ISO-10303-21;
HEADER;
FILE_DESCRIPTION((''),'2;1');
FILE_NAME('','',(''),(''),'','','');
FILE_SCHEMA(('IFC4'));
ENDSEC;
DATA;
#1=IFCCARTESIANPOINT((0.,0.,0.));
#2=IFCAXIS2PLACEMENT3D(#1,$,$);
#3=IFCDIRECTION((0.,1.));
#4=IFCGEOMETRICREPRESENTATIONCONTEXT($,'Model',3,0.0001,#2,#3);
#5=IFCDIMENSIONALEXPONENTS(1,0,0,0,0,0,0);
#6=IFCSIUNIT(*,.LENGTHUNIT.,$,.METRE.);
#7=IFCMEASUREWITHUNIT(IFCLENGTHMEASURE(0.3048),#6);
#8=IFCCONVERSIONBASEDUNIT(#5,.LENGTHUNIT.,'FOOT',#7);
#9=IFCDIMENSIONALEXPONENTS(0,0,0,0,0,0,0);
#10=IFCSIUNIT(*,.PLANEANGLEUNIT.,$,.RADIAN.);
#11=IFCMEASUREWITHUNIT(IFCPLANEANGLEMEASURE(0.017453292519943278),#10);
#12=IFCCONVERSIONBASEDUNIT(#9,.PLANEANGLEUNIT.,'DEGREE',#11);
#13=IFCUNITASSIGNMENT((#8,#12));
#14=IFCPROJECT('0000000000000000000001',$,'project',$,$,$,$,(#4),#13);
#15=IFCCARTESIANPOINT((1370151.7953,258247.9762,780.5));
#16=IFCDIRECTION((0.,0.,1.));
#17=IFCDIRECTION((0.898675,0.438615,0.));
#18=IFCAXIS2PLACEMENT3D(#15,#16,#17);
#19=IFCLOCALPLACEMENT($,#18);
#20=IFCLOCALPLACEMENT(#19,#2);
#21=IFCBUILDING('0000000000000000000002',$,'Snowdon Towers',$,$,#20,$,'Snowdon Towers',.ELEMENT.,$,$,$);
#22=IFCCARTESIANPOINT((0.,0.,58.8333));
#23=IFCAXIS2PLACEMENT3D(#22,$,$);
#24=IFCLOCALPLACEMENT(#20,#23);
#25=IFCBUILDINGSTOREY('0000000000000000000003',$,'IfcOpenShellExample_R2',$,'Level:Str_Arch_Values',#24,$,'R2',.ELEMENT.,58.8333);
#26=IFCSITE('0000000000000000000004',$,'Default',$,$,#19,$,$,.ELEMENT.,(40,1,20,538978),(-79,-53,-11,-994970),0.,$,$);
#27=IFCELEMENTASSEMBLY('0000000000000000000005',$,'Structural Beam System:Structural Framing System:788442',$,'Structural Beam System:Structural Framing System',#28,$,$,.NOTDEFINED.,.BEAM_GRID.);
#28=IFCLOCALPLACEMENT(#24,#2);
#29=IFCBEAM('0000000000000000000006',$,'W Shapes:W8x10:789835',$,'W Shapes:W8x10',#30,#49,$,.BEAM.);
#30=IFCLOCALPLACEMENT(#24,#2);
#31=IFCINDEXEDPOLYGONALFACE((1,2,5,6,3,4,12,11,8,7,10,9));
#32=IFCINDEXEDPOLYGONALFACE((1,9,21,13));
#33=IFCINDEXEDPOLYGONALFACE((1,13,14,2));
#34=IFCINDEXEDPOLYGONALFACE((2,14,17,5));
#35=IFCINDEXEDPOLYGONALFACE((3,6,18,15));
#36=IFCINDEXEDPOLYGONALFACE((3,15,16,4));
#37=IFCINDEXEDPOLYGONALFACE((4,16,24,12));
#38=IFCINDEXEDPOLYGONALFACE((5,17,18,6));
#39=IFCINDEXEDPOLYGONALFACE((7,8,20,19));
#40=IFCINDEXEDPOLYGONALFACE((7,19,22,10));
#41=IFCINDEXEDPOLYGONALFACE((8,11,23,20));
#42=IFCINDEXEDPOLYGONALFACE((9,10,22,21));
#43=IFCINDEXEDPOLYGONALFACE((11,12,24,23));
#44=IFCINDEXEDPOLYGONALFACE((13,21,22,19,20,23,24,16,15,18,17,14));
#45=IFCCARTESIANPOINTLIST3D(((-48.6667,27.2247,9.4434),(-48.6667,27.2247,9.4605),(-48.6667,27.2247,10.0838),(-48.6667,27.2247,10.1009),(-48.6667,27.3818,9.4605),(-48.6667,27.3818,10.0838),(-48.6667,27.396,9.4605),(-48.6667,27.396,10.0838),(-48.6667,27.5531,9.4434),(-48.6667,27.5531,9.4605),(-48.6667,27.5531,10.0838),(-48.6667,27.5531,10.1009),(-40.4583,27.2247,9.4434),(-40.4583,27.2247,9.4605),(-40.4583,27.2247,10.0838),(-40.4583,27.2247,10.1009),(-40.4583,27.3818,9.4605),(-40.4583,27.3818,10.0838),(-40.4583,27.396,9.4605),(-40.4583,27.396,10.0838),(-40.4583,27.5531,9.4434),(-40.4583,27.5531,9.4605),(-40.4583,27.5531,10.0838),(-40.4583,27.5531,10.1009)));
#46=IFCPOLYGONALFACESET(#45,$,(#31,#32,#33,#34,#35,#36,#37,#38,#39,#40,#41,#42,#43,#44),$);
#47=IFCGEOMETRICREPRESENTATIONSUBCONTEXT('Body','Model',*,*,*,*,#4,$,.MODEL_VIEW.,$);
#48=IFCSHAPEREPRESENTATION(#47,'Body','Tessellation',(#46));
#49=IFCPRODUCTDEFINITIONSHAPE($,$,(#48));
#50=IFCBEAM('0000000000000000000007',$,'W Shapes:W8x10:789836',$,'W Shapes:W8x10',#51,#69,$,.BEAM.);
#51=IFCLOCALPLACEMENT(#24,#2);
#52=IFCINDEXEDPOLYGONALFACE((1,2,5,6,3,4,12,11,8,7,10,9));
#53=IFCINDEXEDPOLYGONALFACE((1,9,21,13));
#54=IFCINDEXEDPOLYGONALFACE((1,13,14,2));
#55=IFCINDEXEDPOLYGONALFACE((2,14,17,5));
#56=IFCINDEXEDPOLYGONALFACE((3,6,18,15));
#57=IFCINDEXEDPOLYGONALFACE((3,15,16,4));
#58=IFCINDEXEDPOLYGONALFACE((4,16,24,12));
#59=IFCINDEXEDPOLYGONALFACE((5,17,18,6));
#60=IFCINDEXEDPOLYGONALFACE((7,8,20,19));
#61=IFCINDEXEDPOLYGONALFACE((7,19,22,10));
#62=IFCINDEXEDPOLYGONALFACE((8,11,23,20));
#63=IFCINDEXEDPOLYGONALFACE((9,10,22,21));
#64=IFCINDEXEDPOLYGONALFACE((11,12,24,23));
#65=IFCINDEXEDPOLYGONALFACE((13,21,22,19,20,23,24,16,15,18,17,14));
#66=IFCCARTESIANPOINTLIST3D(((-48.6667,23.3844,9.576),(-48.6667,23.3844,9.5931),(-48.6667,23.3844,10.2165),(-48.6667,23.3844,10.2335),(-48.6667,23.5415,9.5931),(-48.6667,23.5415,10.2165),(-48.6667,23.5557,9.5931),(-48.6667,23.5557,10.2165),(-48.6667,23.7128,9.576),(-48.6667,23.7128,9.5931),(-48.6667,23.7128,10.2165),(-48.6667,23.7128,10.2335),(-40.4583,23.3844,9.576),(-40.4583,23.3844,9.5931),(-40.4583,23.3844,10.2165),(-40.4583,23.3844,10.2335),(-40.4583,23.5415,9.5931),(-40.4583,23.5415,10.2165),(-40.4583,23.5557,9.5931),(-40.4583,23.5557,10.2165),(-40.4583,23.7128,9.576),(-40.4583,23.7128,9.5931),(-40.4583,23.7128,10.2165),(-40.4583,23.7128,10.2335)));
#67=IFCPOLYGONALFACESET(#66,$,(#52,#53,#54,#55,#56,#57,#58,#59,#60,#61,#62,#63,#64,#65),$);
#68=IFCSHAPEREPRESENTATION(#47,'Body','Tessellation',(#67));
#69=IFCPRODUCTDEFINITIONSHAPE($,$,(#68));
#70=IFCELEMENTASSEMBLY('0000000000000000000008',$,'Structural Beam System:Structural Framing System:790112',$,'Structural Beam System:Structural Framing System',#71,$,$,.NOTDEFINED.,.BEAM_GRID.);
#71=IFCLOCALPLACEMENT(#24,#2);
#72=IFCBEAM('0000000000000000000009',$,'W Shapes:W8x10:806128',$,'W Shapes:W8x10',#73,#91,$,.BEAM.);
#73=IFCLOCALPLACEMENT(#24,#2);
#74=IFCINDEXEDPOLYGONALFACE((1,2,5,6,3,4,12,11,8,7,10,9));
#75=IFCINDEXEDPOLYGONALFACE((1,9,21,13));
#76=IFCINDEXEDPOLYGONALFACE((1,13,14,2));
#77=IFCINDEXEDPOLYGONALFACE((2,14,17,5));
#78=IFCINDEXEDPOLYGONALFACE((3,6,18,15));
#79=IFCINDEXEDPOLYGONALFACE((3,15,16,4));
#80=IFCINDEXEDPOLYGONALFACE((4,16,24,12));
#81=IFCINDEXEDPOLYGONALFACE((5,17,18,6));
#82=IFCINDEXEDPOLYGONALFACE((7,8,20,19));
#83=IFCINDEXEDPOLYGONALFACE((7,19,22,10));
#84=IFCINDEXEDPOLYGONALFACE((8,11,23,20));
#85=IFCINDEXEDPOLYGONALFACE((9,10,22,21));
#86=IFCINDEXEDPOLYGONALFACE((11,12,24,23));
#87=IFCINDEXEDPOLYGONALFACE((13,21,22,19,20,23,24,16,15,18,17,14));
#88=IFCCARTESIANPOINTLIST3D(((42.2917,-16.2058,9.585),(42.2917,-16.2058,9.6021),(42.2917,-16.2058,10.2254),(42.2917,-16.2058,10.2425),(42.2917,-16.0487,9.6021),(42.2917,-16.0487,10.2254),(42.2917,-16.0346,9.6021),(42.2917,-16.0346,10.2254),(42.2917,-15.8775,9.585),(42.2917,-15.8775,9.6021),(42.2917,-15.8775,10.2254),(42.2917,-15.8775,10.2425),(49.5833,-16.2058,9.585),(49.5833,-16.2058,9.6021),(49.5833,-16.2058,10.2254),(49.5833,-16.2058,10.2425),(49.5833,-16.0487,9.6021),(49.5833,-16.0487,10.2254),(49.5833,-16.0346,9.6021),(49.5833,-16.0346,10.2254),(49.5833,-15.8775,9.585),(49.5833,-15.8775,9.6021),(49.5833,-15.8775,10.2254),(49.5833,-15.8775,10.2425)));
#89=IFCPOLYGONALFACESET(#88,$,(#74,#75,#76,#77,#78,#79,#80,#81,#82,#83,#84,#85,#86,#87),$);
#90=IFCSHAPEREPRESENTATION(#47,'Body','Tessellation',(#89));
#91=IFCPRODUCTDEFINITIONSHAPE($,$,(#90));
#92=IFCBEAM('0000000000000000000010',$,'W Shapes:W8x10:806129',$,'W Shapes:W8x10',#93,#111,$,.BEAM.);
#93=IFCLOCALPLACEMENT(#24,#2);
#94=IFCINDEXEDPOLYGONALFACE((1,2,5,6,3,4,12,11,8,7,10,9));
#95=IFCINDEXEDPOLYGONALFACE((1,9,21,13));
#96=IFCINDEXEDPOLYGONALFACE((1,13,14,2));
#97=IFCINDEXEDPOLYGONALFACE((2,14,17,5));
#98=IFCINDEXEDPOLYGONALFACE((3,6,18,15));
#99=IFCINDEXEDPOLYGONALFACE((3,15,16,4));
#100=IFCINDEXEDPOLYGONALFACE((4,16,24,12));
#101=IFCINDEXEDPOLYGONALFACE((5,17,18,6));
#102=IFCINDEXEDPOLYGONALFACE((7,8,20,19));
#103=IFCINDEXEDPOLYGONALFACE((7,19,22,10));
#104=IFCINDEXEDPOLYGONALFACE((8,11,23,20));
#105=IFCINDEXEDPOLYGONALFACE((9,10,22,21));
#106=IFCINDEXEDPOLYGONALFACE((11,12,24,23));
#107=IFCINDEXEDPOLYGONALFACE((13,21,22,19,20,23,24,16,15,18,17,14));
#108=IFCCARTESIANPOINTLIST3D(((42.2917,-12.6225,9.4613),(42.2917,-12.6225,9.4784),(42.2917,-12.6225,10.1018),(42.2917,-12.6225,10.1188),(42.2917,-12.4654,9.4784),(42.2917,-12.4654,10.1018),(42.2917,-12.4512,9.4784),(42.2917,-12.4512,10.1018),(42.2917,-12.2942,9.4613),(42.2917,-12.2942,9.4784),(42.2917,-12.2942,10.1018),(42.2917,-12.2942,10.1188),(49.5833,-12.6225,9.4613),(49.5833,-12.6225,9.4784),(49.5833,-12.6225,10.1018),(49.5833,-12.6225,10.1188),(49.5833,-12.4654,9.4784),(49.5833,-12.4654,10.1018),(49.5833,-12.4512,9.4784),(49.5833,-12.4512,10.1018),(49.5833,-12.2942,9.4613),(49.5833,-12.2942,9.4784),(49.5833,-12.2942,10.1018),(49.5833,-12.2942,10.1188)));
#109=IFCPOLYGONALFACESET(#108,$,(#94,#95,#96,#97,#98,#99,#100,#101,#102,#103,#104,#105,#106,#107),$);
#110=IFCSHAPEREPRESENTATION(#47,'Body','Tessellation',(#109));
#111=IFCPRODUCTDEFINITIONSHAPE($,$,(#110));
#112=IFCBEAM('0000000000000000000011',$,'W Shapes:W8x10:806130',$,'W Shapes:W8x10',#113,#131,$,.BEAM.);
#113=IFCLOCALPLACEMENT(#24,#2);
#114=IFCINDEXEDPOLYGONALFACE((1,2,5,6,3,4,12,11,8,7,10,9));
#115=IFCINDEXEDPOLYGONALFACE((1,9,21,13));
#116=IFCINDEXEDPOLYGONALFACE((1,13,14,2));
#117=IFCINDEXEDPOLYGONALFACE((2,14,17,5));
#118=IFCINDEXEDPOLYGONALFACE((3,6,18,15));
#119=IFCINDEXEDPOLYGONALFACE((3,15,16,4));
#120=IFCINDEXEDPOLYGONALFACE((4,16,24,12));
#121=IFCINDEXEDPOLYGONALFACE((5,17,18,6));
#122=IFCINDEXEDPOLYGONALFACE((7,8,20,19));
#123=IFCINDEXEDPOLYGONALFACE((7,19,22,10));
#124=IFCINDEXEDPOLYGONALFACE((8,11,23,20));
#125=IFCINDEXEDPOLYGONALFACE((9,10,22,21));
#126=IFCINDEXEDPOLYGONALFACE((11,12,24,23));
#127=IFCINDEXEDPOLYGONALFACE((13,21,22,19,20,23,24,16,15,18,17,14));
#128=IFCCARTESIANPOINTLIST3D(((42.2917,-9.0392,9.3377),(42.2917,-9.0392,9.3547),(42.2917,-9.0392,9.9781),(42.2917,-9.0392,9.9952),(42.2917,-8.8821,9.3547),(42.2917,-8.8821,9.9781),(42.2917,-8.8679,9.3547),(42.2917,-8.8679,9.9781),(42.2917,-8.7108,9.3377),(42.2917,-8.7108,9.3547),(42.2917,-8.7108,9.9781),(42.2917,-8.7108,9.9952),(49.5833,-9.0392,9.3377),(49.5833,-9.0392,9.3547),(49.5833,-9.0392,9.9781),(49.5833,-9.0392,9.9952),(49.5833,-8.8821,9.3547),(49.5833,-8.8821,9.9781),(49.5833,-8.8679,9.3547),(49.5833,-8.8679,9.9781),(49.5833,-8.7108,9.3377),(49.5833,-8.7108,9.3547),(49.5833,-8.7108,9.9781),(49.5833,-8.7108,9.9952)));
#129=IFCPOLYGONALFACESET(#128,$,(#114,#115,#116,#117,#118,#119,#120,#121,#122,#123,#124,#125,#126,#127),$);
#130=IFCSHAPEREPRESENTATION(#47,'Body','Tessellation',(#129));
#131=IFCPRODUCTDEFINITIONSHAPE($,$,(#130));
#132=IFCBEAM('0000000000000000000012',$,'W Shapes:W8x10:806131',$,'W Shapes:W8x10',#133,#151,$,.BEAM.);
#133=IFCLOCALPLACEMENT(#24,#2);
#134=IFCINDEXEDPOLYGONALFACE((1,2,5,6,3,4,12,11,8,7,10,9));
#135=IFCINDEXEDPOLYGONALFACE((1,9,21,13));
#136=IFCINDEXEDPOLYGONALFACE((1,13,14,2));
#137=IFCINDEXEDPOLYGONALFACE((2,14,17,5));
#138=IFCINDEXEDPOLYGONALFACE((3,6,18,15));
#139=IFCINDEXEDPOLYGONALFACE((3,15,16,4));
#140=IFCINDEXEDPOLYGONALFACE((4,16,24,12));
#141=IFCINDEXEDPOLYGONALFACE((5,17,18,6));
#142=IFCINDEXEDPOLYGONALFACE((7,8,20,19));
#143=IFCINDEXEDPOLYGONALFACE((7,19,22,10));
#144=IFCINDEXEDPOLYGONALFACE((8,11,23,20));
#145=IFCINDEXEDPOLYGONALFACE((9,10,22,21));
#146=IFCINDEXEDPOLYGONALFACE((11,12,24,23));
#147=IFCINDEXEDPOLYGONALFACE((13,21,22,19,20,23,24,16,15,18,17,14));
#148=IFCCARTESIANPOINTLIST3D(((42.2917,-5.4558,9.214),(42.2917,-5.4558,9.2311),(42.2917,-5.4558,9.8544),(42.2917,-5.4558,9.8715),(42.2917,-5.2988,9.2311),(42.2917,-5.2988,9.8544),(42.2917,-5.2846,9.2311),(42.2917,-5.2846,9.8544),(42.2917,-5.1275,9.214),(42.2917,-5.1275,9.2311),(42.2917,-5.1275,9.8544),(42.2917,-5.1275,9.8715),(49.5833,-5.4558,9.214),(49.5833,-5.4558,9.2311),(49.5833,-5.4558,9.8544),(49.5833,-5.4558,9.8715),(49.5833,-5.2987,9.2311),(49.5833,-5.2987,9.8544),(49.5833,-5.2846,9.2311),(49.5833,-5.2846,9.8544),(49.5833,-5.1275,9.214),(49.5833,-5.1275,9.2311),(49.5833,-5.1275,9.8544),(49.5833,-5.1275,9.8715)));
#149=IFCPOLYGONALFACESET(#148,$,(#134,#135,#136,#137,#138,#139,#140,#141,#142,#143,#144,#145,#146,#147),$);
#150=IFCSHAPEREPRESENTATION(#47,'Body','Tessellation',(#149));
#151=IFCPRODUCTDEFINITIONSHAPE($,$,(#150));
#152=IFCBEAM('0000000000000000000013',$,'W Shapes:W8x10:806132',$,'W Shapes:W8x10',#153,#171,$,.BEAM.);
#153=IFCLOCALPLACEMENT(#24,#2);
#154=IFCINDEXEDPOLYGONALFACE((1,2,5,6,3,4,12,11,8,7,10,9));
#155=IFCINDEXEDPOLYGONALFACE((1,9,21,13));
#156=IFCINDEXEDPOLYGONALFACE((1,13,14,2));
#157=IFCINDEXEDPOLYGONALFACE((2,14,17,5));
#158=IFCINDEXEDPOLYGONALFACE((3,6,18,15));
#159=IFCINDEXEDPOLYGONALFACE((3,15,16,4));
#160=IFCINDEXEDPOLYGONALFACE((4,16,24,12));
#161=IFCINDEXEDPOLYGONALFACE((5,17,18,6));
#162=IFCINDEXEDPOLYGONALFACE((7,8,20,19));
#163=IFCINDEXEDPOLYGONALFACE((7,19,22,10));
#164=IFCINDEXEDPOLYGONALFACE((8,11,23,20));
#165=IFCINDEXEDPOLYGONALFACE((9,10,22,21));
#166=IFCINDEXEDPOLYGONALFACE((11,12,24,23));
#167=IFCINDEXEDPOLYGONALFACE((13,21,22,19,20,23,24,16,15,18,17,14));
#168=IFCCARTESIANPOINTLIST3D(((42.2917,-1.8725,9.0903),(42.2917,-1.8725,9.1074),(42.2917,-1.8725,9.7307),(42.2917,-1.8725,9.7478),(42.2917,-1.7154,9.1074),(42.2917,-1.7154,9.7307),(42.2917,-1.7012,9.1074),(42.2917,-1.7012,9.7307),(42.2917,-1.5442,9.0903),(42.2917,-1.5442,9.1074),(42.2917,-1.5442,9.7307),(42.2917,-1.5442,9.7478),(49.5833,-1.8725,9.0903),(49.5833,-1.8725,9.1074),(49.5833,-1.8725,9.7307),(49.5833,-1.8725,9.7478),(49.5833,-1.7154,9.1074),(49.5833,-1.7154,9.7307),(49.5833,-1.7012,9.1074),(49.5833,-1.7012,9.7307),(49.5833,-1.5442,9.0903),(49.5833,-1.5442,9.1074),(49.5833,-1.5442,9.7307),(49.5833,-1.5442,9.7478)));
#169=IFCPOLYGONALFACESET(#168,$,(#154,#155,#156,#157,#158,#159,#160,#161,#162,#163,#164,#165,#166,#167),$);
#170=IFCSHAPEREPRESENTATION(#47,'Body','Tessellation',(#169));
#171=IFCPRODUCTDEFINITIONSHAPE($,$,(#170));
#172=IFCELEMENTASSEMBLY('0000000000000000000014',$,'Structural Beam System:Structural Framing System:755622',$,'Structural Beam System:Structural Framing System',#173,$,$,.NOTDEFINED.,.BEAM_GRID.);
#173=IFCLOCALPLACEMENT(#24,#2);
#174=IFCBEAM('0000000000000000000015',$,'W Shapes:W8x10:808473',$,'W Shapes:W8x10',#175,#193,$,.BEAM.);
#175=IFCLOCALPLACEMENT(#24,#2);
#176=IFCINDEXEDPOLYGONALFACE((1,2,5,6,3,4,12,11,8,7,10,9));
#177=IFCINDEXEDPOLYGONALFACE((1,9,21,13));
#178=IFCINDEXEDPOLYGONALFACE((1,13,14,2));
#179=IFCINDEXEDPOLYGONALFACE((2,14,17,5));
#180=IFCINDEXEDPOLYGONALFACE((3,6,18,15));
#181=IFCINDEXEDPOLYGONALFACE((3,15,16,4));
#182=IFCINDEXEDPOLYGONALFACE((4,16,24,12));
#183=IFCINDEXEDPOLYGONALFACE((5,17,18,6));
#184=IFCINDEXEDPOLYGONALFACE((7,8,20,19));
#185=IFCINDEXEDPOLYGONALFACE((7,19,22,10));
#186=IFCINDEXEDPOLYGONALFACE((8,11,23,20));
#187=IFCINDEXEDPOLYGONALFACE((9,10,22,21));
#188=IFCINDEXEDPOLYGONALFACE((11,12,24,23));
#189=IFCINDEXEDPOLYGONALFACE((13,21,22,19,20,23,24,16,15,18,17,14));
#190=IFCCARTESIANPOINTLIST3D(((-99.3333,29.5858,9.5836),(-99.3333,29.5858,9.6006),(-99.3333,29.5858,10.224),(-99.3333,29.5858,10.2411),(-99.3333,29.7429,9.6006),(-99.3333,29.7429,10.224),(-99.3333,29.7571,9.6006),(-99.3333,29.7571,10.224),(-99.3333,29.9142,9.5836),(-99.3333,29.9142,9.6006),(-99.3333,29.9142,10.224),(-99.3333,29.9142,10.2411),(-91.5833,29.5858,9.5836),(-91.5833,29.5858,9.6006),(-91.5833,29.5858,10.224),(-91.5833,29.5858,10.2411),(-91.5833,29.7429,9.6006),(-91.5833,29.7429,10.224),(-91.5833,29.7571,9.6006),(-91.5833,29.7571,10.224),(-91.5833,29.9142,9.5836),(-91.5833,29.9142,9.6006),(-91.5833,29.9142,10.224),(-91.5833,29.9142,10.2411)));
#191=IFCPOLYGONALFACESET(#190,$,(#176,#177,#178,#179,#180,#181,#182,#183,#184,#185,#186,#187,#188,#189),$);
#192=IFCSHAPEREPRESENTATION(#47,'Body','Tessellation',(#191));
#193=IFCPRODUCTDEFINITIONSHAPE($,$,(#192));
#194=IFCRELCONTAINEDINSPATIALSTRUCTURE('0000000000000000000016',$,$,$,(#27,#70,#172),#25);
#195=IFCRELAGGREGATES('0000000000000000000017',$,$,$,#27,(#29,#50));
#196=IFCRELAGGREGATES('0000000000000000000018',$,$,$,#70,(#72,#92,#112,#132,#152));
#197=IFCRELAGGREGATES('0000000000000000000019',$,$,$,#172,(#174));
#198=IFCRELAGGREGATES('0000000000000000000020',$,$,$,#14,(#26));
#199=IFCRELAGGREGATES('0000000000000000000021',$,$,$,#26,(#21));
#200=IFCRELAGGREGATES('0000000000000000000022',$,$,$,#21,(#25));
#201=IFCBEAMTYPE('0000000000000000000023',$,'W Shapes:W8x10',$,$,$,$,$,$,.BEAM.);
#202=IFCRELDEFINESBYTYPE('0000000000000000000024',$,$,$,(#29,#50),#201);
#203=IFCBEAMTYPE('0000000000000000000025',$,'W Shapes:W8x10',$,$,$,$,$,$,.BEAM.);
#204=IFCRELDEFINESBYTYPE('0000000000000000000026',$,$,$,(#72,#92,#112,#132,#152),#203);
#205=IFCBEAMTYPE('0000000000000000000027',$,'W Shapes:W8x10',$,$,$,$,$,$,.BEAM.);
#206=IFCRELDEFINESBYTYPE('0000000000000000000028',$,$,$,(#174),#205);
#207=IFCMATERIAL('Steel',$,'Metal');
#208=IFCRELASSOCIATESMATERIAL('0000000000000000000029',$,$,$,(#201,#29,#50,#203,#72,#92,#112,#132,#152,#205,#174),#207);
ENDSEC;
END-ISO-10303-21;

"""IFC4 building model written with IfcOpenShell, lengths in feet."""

from ifc_helpers import new_model, entity, si_unit, converted_unit, direction, frame, origin, place, context, subcontext, project, spatial, indexed_curve, outline, extrude, source, transform, mapped, material, type_object, type_shapes, element, aggregate, save


model = new_model("IFC4")

# Units and contexts
model_context = context("Model", 3, precision=0.0001, world=origin(), true_north=direction((0.0, 1.0)))
body_context = subcontext(model_context, "Body", "Model", "MODEL_VIEW")
ifc_project = project(units=[converted_unit("LENGTHUNIT", "FOOT", entity("IfcLengthMeasure", 0.3048), si_unit("LENGTHUNIT", "METRE"), dimensions=[1, 0, 0, 0, 0, 0, 0]), converted_unit("PLANEANGLEUNIT", "DEGREE", entity("IfcPlaneAngleMeasure", 0.017453292519943278), si_unit("PLANEANGLEUNIT", "RADIAN"), dimensions=[0, 0, 0, 0, 0, 0, 0])], contexts=[model_context])

# Site, building, storey
site_placement = place(None, frame((1370151.7953, 258247.9762, 780.5), z_axis=(0.0, 0.0, 1.0), x_axis=(0.898675, 0.438615, 0.0)))
site = spatial("IfcSite", under=ifc_project, at=site_placement, Name="Default", CompositionType="ELEMENT", RefLatitude=(40, 1, 20, 538978), RefLongitude=(-79, -53, -11, -994970), RefElevation=0.0)
building_placement = place(site_placement, origin())
building = spatial("IfcBuilding", under=site, at=building_placement, Name="Snowdon Towers", LongName="Snowdon Towers", CompositionType="ELEMENT")
storey_placement = place(building_placement, frame((0.0, 0.0, 58.8333)))
storey = spatial("IfcBuildingStorey", under=building, at=storey_placement, Name="IfcOpenShellExample_R2", ObjectType="Level:Str_Arch_Values", LongName="R2", CompositionType="ELEMENT", Elevation=58.8333)

# Element assemblies, beams
ifc_material_1 = material(Name="Steel", Category="Metal")
assembly_1_placement = place(storey_placement, origin())
assembly_1 = element("IfcElementAssembly", 1, at=assembly_1_placement, inside=storey, Name="Structural Beam System:Structural Framing System:788442", ObjectType="Structural Beam System:Structural Framing System", AssemblyPlace="NOTDEFINED", PredefinedType="BEAM_GRID")
beam_type_1 = type_object("IfcBeamType", Name="W Shapes:W8x10", PredefinedType="BEAM", material=ifc_material_1)
shared_shape_1 = source(origin(), body_context, "Body", "SweptSolid", [
    extrude(outline(indexed_curve([(-0.1642, -0.3117), (-0.1642, -0.3288), (0.1642, -0.3288), (0.1642, -0.3117), (0.0071, -0.3117), (0.0071, 0.3117), (0.1642, 0.3117), (0.1642, 0.3287), (-0.1642, 0.3287), (-0.1642, 0.3117), (-0.0071, 0.3117), (-0.0071, -0.3117), (-0.1642, -0.3117)], self_intersect=False)), frame((-4.1042, 0.0, 0.0), z_axis=(-1.0, 0.0, 0.0), x_axis=(0.0, -1.0, 0.0)), (0.0, 0.0, -1.0), 8.2083),
])
type_shapes(beam_type_1, [shared_shape_1])
beam_1_placement = place(assembly_1_placement, frame((-44.5625, 27.3889, 9.7721)))
beam_1 = element("IfcBeam", 2, at=beam_1_placement, type_object=beam_type_1, material=ifc_material_1, Name="W Shapes:W8x10:789835", ObjectType="W Shapes:W8x10", PredefinedType="BEAM", context=body_context, shape_type="MappedRepresentation", body=[
    mapped(shared_shape_1, transform((0.0, 0.0, 0.0), scale=1.0)),
])
beam_2_placement = place(assembly_1_placement, frame((-44.5625, 23.5486, 9.9048)))
beam_2 = element("IfcBeam", 3, at=beam_2_placement, type_object=beam_type_1, material=ifc_material_1, Name="W Shapes:W8x10:789836", ObjectType="W Shapes:W8x10", PredefinedType="BEAM", context=body_context, shape_type="MappedRepresentation", body=[
    mapped(shared_shape_1, transform((0.0, 0.0, 0.0), scale=1.0)),
])
aggregate(assembly_1, [beam_1, beam_2])
assembly_2_placement = place(storey_placement, origin())
assembly_2 = element("IfcElementAssembly", 4, at=assembly_2_placement, inside=storey, Name="Structural Beam System:Structural Framing System:790112", ObjectType="Structural Beam System:Structural Framing System", AssemblyPlace="NOTDEFINED", PredefinedType="BEAM_GRID")
beam_type_2 = type_object("IfcBeamType", Name="W Shapes:W8x10", PredefinedType="BEAM", material=ifc_material_1)
shared_shape_2 = source(origin(), body_context, "Body", "SweptSolid", [
    extrude(outline(indexed_curve([(-0.1642, -0.3117), (-0.1642, -0.3288), (0.1642, -0.3288), (0.1642, -0.3117), (0.0071, -0.3117), (0.0071, 0.3117), (0.1642, 0.3117), (0.1642, 0.3287), (-0.1642, 0.3287), (-0.1642, 0.3117), (-0.0071, 0.3117), (-0.0071, -0.3117), (-0.1642, -0.3117)], self_intersect=False)), frame((-3.6458, 0.0, 0.0), z_axis=(-1.0, 0.0, 0.0), x_axis=(0.0, -1.0, 0.0)), (0.0, 0.0, -1.0), 7.2917),
])
type_shapes(beam_type_2, [shared_shape_2])
beam_3_placement = place(assembly_2_placement, frame((45.9375, -16.0417, 9.9138), z_axis=(0.0, 0.0, 1.0), x_axis=(-1.0, 0.0, 0.0)))
beam_3 = element("IfcBeam", 5, at=beam_3_placement, type_object=beam_type_2, material=ifc_material_1, Name="W Shapes:W8x10:806128", ObjectType="W Shapes:W8x10", PredefinedType="BEAM", context=body_context, shape_type="MappedRepresentation", body=[
    mapped(shared_shape_2, transform((0.0, 0.0, 0.0), scale=1.0)),
])
beam_4_placement = place(assembly_2_placement, frame((45.9375, -12.4583, 9.7901), z_axis=(0.0, 0.0, 1.0), x_axis=(-1.0, 0.0, 0.0)))
beam_4 = element("IfcBeam", 6, at=beam_4_placement, type_object=beam_type_2, material=ifc_material_1, Name="W Shapes:W8x10:806129", ObjectType="W Shapes:W8x10", PredefinedType="BEAM", context=body_context, shape_type="MappedRepresentation", body=[
    mapped(shared_shape_2, transform((0.0, 0.0, 0.0), scale=1.0)),
])
beam_5_placement = place(assembly_2_placement, frame((45.9375, -8.875, 9.6664), z_axis=(0.0, 0.0, 1.0), x_axis=(-1.0, 0.0, 0.0)))
beam_5 = element("IfcBeam", 7, at=beam_5_placement, type_object=beam_type_2, material=ifc_material_1, Name="W Shapes:W8x10:806130", ObjectType="W Shapes:W8x10", PredefinedType="BEAM", context=body_context, shape_type="MappedRepresentation", body=[
    mapped(shared_shape_2, transform((0.0, 0.0, 0.0), scale=1.0)),
])
beam_6_placement = place(assembly_2_placement, frame((45.9375, -5.2917, 9.5427), z_axis=(0.0, 0.0, 1.0), x_axis=(-1.0, 0.0, 0.0)))
beam_6 = element("IfcBeam", 8, at=beam_6_placement, type_object=beam_type_2, material=ifc_material_1, Name="W Shapes:W8x10:806131", ObjectType="W Shapes:W8x10", PredefinedType="BEAM", context=body_context, shape_type="MappedRepresentation", body=[
    mapped(shared_shape_2, transform((0.0, 0.0, 0.0), scale=1.0)),
])
beam_7_placement = place(assembly_2_placement, frame((45.9375, -1.7083, 9.4191), z_axis=(0.0, 0.0, 1.0), x_axis=(-1.0, 0.0, 0.0)))
beam_7 = element("IfcBeam", 9, at=beam_7_placement, type_object=beam_type_2, material=ifc_material_1, Name="W Shapes:W8x10:806132", ObjectType="W Shapes:W8x10", PredefinedType="BEAM", context=body_context, shape_type="MappedRepresentation", body=[
    mapped(shared_shape_2, transform((0.0, 0.0, 0.0), scale=1.0)),
])
aggregate(assembly_2, [beam_3, beam_4, beam_5, beam_6, beam_7])

# Element assembly, beam
assembly_3_placement = place(storey_placement, origin())
assembly_3 = element("IfcElementAssembly", 10, at=assembly_3_placement, inside=storey, Name="Structural Beam System:Structural Framing System:755622", ObjectType="Structural Beam System:Structural Framing System", AssemblyPlace="NOTDEFINED", PredefinedType="BEAM_GRID")
beam_type_3 = type_object("IfcBeamType", Name="W Shapes:W8x10", PredefinedType="BEAM", material=ifc_material_1)
shared_shape_3 = source(origin(), body_context, "Body", "SweptSolid", [
    extrude(outline(indexed_curve([(-0.1642, -0.3117), (-0.1642, -0.3288), (0.1642, -0.3288), (0.1642, -0.3117), (0.0071, -0.3117), (0.0071, 0.3117), (0.1642, 0.3117), (0.1642, 0.3287), (-0.1642, 0.3287), (-0.1642, 0.3117), (-0.0071, 0.3117), (-0.0071, -0.3117), (-0.1642, -0.3117)], self_intersect=False)), frame((-3.875, 0.0, 0.0), z_axis=(-1.0, 0.0, 0.0), x_axis=(0.0, -1.0, 0.0)), (0.0, 0.0, -1.0), 7.75),
])
type_shapes(beam_type_3, [shared_shape_3])
beam_8_placement = place(assembly_3_placement, frame((-95.4583, 29.75, 9.9123), z_axis=(0.0, 0.0, 1.0), x_axis=(-1.0, 0.0, 0.0)))
beam_8 = element("IfcBeam", 11, at=beam_8_placement, type_object=beam_type_3, material=ifc_material_1, Name="W Shapes:W8x10:808473", ObjectType="W Shapes:W8x10", PredefinedType="BEAM", context=body_context, shape_type="MappedRepresentation", body=[
    mapped(shared_shape_3, transform((0.0, 0.0, 0.0), scale=1.0)),
])
aggregate(assembly_3, [beam_8])

save(model, "model.ifc")
